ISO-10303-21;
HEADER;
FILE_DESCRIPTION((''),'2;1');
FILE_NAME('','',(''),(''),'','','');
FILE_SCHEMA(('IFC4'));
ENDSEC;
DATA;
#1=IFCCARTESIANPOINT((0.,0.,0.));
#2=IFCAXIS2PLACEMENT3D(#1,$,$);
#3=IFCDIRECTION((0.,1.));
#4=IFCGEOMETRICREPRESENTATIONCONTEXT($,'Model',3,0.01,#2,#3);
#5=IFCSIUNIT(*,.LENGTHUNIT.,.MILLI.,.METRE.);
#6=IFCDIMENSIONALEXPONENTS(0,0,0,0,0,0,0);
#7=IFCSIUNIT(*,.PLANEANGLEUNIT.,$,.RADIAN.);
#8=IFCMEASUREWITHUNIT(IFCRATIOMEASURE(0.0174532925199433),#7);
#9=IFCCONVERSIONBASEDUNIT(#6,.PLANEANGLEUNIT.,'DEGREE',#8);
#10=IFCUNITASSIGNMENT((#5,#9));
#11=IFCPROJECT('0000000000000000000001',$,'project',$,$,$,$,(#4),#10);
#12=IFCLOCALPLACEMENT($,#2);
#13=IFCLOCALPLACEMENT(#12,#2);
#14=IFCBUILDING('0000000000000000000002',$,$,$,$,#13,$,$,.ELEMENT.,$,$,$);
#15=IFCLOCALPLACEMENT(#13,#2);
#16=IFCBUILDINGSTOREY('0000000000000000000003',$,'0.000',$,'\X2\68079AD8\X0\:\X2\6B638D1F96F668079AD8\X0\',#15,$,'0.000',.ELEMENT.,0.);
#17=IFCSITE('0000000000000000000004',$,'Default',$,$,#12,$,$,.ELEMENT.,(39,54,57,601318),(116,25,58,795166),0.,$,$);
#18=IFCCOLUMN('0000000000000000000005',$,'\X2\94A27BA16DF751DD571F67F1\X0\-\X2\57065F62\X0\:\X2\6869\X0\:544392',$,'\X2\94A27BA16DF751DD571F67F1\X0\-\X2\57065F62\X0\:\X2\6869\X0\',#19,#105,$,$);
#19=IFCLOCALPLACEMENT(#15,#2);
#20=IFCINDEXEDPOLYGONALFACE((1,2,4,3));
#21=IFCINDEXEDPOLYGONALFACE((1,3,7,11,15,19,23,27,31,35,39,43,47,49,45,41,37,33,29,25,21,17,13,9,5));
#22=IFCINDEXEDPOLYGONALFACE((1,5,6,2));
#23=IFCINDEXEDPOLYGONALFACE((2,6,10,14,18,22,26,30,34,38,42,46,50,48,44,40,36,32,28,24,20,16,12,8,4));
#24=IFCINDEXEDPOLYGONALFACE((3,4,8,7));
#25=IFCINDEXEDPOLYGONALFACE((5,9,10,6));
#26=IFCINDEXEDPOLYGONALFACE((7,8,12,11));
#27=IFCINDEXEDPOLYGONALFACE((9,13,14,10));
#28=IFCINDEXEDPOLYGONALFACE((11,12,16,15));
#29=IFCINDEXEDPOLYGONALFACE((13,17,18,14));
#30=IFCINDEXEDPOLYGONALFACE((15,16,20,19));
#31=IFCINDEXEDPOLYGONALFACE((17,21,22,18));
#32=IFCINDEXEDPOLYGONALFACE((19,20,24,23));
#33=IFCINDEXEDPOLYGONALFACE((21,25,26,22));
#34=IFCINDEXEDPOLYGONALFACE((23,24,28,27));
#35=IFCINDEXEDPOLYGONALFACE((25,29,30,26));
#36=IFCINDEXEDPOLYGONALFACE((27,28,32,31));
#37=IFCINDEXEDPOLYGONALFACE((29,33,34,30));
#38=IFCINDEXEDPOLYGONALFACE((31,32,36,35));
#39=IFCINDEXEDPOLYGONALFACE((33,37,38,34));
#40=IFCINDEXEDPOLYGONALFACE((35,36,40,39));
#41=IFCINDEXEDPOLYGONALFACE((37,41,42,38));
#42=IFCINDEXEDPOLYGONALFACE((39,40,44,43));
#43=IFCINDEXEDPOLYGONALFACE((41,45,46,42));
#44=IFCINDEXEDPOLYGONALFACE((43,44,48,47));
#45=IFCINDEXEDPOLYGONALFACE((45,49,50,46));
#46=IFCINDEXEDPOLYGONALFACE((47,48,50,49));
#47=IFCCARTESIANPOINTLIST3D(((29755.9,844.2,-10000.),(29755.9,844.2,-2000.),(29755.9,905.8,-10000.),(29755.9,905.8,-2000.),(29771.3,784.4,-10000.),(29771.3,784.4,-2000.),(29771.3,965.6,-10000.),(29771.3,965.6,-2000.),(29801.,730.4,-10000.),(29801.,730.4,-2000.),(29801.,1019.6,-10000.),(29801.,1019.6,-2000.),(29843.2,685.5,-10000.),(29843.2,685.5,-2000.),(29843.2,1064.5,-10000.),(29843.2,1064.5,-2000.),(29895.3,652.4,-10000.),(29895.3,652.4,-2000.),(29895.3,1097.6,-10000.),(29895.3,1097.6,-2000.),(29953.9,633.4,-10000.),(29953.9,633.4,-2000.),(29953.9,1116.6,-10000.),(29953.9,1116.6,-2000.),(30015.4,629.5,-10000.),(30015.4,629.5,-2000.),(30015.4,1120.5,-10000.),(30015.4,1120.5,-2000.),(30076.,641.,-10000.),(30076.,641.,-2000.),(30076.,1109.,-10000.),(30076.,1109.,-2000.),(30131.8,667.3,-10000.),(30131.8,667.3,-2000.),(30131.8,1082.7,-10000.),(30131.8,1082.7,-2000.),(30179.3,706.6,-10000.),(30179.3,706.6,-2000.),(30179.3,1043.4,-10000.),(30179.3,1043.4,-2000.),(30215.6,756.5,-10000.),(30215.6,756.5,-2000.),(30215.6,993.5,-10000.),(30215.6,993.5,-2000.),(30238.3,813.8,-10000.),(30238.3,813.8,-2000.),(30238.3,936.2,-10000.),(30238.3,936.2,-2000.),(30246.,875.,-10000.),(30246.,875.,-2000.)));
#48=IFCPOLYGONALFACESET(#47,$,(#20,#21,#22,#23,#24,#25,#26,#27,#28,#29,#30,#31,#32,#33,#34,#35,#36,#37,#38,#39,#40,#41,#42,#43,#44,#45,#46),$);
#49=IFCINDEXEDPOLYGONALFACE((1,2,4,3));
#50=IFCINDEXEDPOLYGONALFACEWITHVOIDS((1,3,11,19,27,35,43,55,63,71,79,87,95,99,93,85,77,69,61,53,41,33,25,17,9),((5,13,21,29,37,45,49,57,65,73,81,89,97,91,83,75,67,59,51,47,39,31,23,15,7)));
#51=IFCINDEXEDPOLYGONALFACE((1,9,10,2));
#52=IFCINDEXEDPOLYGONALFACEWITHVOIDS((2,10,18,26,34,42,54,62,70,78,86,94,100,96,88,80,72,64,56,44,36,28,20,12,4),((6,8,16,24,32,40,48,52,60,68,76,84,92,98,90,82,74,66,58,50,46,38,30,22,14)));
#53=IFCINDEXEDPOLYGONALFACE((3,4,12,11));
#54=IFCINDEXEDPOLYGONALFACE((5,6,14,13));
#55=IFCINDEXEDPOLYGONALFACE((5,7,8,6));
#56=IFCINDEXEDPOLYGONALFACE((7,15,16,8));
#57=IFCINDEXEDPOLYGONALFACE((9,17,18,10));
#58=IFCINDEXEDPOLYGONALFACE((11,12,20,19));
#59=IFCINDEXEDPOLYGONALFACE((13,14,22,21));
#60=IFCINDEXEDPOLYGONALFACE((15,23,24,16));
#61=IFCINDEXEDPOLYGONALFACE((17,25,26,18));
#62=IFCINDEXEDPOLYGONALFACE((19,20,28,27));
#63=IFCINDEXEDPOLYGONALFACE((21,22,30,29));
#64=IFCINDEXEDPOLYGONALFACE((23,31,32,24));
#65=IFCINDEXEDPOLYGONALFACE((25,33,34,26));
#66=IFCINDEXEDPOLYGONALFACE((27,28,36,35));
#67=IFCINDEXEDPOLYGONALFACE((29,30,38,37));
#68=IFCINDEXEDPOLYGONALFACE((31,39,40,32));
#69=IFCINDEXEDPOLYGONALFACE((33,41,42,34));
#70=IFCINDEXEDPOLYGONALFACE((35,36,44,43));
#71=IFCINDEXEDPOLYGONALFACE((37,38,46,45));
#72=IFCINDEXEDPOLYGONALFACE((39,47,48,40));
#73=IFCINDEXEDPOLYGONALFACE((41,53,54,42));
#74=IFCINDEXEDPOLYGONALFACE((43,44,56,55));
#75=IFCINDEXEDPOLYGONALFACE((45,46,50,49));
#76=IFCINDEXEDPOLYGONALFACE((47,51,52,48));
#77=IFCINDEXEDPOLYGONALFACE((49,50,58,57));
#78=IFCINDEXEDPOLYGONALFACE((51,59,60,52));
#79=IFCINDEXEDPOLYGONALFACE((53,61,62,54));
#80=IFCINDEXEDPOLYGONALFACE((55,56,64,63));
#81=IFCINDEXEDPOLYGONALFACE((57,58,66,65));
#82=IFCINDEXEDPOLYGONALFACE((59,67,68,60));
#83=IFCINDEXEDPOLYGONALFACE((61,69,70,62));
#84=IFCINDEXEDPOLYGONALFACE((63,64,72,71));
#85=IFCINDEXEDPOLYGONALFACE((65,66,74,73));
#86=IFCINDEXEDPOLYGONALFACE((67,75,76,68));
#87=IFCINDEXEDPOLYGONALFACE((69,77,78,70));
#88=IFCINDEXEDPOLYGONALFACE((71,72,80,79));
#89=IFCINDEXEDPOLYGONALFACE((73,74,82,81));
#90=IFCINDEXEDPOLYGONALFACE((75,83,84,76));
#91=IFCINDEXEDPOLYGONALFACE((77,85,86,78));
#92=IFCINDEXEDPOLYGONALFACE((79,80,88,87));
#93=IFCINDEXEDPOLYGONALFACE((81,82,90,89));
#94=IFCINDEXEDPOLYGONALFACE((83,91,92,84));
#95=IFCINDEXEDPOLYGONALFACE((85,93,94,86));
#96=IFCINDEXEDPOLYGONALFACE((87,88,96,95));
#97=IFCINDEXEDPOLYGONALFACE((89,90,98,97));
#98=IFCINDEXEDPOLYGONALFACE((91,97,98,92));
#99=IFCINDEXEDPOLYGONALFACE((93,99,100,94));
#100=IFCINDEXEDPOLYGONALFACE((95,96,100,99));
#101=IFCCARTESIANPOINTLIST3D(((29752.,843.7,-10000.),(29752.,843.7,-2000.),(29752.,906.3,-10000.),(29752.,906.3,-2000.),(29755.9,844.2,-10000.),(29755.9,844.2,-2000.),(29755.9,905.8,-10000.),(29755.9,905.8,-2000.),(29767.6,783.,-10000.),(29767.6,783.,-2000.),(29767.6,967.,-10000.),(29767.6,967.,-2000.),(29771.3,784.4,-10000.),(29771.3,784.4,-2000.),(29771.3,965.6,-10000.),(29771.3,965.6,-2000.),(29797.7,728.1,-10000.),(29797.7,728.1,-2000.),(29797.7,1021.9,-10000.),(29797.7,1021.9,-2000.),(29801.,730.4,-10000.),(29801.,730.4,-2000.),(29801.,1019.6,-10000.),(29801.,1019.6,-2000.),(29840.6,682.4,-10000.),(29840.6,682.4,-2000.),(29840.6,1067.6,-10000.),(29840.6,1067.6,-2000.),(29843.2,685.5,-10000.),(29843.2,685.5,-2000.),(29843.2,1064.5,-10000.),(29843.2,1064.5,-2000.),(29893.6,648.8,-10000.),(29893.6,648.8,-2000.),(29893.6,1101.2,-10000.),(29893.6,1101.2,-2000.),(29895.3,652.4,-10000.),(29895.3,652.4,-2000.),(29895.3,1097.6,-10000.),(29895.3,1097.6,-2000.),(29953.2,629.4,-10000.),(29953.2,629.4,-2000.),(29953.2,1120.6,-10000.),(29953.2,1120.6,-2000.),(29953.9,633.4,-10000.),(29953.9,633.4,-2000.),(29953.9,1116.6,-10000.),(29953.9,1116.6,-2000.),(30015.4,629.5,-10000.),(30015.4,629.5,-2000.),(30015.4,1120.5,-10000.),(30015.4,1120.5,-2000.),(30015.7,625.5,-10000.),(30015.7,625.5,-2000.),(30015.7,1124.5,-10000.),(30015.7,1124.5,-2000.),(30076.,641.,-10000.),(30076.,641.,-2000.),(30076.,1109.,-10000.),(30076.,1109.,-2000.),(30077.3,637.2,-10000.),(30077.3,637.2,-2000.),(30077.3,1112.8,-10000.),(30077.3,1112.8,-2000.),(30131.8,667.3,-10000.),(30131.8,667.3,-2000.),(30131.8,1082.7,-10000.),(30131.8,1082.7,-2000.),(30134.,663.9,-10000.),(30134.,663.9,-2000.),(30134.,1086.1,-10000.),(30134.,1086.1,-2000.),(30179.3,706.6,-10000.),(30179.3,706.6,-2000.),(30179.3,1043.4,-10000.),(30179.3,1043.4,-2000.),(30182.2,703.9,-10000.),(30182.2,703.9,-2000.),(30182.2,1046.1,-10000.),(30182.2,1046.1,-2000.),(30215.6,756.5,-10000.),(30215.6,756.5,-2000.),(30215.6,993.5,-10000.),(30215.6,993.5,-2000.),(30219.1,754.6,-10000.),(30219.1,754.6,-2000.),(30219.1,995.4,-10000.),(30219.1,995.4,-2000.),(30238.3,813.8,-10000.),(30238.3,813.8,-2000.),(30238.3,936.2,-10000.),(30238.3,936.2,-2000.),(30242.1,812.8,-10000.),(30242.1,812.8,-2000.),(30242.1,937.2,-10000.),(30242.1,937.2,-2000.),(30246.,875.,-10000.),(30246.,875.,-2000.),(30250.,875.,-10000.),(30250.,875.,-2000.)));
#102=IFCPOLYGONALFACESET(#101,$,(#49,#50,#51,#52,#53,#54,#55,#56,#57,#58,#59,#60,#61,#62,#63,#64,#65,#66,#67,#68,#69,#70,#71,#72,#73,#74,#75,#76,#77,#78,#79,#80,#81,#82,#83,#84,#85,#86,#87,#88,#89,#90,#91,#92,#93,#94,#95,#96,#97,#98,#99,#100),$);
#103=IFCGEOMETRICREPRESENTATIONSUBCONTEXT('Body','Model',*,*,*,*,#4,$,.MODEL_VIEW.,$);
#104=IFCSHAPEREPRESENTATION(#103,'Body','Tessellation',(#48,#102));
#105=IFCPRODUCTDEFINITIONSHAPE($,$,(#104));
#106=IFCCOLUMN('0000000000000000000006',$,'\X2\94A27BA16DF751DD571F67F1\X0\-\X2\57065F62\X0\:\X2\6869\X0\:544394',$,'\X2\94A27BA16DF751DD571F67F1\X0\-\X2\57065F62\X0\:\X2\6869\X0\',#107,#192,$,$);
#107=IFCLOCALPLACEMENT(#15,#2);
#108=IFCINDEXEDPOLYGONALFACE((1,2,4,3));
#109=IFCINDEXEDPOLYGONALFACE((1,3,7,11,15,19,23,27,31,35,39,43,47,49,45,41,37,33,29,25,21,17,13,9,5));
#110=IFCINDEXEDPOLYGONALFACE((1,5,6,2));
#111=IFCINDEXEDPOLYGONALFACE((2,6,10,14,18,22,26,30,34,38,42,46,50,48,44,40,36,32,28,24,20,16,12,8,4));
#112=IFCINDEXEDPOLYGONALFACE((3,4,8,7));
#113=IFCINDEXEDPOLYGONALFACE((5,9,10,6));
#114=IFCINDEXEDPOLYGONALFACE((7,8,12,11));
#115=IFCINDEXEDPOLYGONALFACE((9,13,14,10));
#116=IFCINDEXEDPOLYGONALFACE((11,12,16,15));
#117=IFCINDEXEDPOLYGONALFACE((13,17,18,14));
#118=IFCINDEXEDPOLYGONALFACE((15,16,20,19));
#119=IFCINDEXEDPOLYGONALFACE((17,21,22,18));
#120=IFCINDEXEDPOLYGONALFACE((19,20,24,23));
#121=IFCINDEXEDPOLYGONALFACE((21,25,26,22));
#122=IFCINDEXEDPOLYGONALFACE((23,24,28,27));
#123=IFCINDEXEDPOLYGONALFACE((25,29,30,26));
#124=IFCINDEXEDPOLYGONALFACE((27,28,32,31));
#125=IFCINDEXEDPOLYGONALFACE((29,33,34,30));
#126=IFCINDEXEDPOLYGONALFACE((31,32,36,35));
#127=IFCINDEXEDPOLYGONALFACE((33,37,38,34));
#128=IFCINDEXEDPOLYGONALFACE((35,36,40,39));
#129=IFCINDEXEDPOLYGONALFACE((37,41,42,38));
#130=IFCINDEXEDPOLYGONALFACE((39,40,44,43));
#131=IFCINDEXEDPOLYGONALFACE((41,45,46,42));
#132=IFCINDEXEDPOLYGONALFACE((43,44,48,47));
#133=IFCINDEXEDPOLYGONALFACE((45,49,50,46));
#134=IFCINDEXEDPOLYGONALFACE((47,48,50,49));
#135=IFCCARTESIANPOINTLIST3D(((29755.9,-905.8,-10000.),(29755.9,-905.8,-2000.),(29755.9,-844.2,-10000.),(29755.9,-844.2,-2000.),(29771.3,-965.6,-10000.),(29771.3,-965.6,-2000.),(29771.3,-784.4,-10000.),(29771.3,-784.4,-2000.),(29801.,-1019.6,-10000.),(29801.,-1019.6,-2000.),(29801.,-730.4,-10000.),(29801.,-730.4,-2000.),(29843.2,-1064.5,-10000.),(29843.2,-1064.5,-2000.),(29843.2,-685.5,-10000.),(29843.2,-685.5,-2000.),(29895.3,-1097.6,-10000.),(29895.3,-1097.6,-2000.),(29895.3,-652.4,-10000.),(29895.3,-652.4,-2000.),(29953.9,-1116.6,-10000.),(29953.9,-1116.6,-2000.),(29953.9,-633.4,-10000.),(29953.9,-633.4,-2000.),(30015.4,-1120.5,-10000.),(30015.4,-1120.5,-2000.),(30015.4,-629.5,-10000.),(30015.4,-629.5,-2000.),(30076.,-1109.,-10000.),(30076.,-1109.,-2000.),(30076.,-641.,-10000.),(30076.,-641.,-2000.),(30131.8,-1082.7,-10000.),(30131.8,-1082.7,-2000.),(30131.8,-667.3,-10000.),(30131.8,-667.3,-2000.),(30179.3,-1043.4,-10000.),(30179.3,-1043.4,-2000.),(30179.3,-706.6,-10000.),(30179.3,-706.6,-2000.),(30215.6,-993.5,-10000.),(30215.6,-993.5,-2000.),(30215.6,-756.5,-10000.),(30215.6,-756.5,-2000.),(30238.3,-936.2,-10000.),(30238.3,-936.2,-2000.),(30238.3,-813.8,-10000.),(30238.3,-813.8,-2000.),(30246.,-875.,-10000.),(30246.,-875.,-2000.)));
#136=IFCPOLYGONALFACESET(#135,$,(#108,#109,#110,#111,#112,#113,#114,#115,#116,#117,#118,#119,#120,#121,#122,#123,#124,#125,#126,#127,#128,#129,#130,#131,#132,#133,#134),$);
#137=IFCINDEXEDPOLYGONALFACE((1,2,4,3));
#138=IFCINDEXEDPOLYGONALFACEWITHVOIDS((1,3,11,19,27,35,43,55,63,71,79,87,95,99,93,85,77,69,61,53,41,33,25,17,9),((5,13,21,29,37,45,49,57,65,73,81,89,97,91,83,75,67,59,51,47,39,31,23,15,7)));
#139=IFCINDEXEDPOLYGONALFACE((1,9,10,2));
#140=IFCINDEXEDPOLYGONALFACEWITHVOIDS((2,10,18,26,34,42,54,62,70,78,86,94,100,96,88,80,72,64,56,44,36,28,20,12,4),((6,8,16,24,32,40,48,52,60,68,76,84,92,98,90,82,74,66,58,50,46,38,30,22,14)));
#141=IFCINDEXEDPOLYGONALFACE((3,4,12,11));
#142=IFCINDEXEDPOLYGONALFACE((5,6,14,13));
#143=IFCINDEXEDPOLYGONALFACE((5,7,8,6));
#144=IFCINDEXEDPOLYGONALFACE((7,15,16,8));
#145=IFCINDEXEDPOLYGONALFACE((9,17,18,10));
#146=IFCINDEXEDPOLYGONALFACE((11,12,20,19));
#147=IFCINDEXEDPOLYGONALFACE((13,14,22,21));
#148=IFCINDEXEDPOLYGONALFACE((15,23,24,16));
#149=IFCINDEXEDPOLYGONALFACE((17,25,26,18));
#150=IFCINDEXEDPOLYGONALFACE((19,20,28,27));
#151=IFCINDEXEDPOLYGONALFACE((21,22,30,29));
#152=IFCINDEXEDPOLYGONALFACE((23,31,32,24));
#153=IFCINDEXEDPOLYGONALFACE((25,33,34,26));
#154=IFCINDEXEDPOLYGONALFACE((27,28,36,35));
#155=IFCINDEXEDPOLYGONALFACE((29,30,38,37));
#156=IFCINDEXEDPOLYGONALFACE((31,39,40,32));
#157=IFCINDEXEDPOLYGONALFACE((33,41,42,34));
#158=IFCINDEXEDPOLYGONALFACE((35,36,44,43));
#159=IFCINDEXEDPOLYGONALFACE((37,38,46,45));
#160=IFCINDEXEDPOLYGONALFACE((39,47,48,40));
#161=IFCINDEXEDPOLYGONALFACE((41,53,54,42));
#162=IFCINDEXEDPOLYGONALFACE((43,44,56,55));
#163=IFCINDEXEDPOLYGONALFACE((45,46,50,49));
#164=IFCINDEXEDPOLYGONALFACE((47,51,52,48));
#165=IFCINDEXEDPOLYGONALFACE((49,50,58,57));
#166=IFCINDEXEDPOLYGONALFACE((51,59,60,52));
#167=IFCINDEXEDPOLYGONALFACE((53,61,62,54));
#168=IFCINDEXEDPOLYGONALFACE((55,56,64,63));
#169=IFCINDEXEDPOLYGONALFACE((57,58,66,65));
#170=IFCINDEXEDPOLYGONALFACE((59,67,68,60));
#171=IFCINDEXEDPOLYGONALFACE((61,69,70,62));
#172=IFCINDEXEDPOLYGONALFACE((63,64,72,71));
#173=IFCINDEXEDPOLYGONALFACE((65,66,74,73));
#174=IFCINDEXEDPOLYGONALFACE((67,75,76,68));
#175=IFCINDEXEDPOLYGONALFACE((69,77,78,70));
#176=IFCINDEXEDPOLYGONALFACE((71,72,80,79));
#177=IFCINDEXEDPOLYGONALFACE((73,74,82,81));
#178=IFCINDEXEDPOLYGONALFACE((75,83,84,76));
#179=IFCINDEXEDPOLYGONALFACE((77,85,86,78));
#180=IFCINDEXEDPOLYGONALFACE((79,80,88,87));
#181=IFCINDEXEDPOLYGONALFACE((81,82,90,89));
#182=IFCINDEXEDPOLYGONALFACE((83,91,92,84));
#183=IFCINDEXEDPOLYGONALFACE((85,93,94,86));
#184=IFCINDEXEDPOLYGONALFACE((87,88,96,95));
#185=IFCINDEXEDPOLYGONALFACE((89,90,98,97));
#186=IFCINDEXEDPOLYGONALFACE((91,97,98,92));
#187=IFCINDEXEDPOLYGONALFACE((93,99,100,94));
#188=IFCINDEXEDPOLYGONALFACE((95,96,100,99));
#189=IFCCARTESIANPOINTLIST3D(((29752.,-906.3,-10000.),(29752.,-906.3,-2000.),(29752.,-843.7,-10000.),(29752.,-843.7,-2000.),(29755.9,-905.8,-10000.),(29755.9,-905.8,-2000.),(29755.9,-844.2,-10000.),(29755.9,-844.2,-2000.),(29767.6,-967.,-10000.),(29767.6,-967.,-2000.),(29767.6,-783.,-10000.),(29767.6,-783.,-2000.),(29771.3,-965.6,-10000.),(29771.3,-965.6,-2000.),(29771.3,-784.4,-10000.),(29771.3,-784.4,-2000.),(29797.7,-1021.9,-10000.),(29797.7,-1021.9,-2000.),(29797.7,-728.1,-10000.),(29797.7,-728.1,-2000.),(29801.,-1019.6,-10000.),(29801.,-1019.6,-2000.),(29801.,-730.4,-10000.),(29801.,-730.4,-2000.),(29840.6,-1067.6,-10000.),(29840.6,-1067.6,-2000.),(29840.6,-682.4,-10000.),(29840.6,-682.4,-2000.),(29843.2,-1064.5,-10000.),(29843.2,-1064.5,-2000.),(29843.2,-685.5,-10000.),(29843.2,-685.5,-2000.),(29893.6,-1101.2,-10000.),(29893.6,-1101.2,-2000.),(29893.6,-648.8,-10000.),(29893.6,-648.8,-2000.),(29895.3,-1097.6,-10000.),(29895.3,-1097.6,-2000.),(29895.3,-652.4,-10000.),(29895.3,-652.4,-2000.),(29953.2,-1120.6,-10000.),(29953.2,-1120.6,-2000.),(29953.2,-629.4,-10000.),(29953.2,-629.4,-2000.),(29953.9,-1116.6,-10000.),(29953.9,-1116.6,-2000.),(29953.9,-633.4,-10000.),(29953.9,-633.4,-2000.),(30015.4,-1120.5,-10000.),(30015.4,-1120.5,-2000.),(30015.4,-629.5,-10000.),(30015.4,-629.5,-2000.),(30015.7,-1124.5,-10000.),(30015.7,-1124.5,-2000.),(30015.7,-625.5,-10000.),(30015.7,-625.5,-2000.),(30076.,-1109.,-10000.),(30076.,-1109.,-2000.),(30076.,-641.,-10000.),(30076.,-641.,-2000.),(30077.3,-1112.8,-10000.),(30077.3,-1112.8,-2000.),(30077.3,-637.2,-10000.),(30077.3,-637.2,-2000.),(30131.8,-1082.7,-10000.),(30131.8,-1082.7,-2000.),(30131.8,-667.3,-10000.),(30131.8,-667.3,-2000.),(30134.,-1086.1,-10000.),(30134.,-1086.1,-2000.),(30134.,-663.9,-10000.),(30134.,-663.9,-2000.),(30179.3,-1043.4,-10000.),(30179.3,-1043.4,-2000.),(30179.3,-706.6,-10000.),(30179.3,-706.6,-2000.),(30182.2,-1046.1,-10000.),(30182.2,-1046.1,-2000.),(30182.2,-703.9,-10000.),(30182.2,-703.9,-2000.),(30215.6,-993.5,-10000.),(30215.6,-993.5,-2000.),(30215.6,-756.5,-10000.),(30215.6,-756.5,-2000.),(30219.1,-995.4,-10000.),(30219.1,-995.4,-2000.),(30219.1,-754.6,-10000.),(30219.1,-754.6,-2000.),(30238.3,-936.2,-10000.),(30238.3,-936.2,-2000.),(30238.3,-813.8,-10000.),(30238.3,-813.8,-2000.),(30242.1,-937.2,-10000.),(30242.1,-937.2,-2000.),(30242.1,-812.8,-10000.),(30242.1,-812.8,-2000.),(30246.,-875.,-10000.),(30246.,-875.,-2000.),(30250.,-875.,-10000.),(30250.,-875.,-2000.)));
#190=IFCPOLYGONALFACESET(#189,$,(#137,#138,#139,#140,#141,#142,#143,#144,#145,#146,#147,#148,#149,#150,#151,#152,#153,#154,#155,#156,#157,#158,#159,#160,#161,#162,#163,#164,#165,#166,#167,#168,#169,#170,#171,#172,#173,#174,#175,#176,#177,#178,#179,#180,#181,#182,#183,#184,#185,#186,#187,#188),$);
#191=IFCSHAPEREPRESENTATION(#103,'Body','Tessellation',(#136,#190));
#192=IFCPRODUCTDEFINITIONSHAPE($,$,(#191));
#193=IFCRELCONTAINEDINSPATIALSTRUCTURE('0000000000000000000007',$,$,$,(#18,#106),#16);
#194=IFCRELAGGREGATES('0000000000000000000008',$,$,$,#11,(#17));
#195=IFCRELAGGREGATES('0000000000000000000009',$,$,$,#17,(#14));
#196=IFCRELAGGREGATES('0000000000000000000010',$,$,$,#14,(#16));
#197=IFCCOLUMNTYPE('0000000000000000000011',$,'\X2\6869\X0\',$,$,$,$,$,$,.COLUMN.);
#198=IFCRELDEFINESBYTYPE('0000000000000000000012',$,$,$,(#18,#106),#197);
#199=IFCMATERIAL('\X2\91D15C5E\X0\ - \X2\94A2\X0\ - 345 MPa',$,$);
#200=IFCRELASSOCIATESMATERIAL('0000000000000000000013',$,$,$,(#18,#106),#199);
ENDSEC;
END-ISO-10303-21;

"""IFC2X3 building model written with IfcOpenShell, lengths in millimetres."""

from ifc_helpers import new_model, entity, si_unit, converted_unit, direction, frame, frame_2d, origin, place, context, subcontext, project, spatial, circle, hollow_circle, extrude, source, transform, mapped, material, type_object, type_shapes, element, save


model = new_model("IFC2X3")

# Units and contexts
model_context = context("Model", 3, precision=0.01, world=origin(), true_north=direction((0.0, 1.0)))
body_context = subcontext(model_context, "Body", "Model", "MODEL_VIEW")
ifc_project = project(units=[si_unit("LENGTHUNIT", "METRE", prefix="MILLI"), converted_unit("PLANEANGLEUNIT", "DEGREE", entity("IfcRatioMeasure", 0.0174532925199433), si_unit("PLANEANGLEUNIT", "RADIAN"), dimensions=[0, 0, 0, 0, 0, 0, 0])], contexts=[model_context])

# Site, building, storey
site_placement = place(None, origin())
site = spatial("IfcSite", under=ifc_project, at=site_placement, Name="Default", CompositionType="ELEMENT", RefLatitude=(39, 54, 57, 601318), RefLongitude=(116, 25, 58, 795166), RefElevation=0.0)
building_placement = place(site_placement, origin())
building = spatial("IfcBuilding", under=site, at=building_placement, CompositionType="ELEMENT")
storey_placement = place(building_placement, origin())
storey = spatial("IfcBuildingStorey", under=building, at=storey_placement, Name="0.000", ObjectType="标高:正负零标高", LongName="0.000", CompositionType="ELEMENT", Elevation=0.0)

# Columns
ifc_material_1 = material(Name="金属 - 钢 - 345 MPa")
column_type = type_object("IfcColumnType", Name="桩", PredefinedType="COLUMN")
shared_shape = source(origin(), body_context, "Body", "SweptSolid", [
    extrude(circle(Radius=246.0, at=frame_2d((0.0, 0.0), x_axis=(1.0, 0.0))), frame((0.0, 0.0, -10000.0)), (0.0, 0.0, 1.0), 8000.0),
    extrude(hollow_circle(Radius=250.0, WallThickness=4.0, at=frame_2d((0.0, 0.0), x_axis=(1.0, 0.0))), frame((0.0, 0.0, -10000.0)), (0.0, 0.0, 1.0), 8000.0),
])
type_shapes(column_type, [shared_shape])
for number, where, name in (
    (1, (30000.0, 875.0, 0.0), "钢管混凝土柱-圆形:桩:544392"),
    (2, (30000.0, -875.0, 0.0), "钢管混凝土柱-圆形:桩:544394"),
):
    element("IfcColumn", number, at=place(storey_placement, frame(where)), inside=storey, type_object=column_type, material=ifc_material_1, Name=name, ObjectType="钢管混凝土柱-圆形:桩", context=body_context, shape_type="MappedRepresentation", body=[
        mapped(shared_shape, transform((0.0, 0.0, 0.0), scale=1.0)),
    ])

save(model, "model.ifc")
